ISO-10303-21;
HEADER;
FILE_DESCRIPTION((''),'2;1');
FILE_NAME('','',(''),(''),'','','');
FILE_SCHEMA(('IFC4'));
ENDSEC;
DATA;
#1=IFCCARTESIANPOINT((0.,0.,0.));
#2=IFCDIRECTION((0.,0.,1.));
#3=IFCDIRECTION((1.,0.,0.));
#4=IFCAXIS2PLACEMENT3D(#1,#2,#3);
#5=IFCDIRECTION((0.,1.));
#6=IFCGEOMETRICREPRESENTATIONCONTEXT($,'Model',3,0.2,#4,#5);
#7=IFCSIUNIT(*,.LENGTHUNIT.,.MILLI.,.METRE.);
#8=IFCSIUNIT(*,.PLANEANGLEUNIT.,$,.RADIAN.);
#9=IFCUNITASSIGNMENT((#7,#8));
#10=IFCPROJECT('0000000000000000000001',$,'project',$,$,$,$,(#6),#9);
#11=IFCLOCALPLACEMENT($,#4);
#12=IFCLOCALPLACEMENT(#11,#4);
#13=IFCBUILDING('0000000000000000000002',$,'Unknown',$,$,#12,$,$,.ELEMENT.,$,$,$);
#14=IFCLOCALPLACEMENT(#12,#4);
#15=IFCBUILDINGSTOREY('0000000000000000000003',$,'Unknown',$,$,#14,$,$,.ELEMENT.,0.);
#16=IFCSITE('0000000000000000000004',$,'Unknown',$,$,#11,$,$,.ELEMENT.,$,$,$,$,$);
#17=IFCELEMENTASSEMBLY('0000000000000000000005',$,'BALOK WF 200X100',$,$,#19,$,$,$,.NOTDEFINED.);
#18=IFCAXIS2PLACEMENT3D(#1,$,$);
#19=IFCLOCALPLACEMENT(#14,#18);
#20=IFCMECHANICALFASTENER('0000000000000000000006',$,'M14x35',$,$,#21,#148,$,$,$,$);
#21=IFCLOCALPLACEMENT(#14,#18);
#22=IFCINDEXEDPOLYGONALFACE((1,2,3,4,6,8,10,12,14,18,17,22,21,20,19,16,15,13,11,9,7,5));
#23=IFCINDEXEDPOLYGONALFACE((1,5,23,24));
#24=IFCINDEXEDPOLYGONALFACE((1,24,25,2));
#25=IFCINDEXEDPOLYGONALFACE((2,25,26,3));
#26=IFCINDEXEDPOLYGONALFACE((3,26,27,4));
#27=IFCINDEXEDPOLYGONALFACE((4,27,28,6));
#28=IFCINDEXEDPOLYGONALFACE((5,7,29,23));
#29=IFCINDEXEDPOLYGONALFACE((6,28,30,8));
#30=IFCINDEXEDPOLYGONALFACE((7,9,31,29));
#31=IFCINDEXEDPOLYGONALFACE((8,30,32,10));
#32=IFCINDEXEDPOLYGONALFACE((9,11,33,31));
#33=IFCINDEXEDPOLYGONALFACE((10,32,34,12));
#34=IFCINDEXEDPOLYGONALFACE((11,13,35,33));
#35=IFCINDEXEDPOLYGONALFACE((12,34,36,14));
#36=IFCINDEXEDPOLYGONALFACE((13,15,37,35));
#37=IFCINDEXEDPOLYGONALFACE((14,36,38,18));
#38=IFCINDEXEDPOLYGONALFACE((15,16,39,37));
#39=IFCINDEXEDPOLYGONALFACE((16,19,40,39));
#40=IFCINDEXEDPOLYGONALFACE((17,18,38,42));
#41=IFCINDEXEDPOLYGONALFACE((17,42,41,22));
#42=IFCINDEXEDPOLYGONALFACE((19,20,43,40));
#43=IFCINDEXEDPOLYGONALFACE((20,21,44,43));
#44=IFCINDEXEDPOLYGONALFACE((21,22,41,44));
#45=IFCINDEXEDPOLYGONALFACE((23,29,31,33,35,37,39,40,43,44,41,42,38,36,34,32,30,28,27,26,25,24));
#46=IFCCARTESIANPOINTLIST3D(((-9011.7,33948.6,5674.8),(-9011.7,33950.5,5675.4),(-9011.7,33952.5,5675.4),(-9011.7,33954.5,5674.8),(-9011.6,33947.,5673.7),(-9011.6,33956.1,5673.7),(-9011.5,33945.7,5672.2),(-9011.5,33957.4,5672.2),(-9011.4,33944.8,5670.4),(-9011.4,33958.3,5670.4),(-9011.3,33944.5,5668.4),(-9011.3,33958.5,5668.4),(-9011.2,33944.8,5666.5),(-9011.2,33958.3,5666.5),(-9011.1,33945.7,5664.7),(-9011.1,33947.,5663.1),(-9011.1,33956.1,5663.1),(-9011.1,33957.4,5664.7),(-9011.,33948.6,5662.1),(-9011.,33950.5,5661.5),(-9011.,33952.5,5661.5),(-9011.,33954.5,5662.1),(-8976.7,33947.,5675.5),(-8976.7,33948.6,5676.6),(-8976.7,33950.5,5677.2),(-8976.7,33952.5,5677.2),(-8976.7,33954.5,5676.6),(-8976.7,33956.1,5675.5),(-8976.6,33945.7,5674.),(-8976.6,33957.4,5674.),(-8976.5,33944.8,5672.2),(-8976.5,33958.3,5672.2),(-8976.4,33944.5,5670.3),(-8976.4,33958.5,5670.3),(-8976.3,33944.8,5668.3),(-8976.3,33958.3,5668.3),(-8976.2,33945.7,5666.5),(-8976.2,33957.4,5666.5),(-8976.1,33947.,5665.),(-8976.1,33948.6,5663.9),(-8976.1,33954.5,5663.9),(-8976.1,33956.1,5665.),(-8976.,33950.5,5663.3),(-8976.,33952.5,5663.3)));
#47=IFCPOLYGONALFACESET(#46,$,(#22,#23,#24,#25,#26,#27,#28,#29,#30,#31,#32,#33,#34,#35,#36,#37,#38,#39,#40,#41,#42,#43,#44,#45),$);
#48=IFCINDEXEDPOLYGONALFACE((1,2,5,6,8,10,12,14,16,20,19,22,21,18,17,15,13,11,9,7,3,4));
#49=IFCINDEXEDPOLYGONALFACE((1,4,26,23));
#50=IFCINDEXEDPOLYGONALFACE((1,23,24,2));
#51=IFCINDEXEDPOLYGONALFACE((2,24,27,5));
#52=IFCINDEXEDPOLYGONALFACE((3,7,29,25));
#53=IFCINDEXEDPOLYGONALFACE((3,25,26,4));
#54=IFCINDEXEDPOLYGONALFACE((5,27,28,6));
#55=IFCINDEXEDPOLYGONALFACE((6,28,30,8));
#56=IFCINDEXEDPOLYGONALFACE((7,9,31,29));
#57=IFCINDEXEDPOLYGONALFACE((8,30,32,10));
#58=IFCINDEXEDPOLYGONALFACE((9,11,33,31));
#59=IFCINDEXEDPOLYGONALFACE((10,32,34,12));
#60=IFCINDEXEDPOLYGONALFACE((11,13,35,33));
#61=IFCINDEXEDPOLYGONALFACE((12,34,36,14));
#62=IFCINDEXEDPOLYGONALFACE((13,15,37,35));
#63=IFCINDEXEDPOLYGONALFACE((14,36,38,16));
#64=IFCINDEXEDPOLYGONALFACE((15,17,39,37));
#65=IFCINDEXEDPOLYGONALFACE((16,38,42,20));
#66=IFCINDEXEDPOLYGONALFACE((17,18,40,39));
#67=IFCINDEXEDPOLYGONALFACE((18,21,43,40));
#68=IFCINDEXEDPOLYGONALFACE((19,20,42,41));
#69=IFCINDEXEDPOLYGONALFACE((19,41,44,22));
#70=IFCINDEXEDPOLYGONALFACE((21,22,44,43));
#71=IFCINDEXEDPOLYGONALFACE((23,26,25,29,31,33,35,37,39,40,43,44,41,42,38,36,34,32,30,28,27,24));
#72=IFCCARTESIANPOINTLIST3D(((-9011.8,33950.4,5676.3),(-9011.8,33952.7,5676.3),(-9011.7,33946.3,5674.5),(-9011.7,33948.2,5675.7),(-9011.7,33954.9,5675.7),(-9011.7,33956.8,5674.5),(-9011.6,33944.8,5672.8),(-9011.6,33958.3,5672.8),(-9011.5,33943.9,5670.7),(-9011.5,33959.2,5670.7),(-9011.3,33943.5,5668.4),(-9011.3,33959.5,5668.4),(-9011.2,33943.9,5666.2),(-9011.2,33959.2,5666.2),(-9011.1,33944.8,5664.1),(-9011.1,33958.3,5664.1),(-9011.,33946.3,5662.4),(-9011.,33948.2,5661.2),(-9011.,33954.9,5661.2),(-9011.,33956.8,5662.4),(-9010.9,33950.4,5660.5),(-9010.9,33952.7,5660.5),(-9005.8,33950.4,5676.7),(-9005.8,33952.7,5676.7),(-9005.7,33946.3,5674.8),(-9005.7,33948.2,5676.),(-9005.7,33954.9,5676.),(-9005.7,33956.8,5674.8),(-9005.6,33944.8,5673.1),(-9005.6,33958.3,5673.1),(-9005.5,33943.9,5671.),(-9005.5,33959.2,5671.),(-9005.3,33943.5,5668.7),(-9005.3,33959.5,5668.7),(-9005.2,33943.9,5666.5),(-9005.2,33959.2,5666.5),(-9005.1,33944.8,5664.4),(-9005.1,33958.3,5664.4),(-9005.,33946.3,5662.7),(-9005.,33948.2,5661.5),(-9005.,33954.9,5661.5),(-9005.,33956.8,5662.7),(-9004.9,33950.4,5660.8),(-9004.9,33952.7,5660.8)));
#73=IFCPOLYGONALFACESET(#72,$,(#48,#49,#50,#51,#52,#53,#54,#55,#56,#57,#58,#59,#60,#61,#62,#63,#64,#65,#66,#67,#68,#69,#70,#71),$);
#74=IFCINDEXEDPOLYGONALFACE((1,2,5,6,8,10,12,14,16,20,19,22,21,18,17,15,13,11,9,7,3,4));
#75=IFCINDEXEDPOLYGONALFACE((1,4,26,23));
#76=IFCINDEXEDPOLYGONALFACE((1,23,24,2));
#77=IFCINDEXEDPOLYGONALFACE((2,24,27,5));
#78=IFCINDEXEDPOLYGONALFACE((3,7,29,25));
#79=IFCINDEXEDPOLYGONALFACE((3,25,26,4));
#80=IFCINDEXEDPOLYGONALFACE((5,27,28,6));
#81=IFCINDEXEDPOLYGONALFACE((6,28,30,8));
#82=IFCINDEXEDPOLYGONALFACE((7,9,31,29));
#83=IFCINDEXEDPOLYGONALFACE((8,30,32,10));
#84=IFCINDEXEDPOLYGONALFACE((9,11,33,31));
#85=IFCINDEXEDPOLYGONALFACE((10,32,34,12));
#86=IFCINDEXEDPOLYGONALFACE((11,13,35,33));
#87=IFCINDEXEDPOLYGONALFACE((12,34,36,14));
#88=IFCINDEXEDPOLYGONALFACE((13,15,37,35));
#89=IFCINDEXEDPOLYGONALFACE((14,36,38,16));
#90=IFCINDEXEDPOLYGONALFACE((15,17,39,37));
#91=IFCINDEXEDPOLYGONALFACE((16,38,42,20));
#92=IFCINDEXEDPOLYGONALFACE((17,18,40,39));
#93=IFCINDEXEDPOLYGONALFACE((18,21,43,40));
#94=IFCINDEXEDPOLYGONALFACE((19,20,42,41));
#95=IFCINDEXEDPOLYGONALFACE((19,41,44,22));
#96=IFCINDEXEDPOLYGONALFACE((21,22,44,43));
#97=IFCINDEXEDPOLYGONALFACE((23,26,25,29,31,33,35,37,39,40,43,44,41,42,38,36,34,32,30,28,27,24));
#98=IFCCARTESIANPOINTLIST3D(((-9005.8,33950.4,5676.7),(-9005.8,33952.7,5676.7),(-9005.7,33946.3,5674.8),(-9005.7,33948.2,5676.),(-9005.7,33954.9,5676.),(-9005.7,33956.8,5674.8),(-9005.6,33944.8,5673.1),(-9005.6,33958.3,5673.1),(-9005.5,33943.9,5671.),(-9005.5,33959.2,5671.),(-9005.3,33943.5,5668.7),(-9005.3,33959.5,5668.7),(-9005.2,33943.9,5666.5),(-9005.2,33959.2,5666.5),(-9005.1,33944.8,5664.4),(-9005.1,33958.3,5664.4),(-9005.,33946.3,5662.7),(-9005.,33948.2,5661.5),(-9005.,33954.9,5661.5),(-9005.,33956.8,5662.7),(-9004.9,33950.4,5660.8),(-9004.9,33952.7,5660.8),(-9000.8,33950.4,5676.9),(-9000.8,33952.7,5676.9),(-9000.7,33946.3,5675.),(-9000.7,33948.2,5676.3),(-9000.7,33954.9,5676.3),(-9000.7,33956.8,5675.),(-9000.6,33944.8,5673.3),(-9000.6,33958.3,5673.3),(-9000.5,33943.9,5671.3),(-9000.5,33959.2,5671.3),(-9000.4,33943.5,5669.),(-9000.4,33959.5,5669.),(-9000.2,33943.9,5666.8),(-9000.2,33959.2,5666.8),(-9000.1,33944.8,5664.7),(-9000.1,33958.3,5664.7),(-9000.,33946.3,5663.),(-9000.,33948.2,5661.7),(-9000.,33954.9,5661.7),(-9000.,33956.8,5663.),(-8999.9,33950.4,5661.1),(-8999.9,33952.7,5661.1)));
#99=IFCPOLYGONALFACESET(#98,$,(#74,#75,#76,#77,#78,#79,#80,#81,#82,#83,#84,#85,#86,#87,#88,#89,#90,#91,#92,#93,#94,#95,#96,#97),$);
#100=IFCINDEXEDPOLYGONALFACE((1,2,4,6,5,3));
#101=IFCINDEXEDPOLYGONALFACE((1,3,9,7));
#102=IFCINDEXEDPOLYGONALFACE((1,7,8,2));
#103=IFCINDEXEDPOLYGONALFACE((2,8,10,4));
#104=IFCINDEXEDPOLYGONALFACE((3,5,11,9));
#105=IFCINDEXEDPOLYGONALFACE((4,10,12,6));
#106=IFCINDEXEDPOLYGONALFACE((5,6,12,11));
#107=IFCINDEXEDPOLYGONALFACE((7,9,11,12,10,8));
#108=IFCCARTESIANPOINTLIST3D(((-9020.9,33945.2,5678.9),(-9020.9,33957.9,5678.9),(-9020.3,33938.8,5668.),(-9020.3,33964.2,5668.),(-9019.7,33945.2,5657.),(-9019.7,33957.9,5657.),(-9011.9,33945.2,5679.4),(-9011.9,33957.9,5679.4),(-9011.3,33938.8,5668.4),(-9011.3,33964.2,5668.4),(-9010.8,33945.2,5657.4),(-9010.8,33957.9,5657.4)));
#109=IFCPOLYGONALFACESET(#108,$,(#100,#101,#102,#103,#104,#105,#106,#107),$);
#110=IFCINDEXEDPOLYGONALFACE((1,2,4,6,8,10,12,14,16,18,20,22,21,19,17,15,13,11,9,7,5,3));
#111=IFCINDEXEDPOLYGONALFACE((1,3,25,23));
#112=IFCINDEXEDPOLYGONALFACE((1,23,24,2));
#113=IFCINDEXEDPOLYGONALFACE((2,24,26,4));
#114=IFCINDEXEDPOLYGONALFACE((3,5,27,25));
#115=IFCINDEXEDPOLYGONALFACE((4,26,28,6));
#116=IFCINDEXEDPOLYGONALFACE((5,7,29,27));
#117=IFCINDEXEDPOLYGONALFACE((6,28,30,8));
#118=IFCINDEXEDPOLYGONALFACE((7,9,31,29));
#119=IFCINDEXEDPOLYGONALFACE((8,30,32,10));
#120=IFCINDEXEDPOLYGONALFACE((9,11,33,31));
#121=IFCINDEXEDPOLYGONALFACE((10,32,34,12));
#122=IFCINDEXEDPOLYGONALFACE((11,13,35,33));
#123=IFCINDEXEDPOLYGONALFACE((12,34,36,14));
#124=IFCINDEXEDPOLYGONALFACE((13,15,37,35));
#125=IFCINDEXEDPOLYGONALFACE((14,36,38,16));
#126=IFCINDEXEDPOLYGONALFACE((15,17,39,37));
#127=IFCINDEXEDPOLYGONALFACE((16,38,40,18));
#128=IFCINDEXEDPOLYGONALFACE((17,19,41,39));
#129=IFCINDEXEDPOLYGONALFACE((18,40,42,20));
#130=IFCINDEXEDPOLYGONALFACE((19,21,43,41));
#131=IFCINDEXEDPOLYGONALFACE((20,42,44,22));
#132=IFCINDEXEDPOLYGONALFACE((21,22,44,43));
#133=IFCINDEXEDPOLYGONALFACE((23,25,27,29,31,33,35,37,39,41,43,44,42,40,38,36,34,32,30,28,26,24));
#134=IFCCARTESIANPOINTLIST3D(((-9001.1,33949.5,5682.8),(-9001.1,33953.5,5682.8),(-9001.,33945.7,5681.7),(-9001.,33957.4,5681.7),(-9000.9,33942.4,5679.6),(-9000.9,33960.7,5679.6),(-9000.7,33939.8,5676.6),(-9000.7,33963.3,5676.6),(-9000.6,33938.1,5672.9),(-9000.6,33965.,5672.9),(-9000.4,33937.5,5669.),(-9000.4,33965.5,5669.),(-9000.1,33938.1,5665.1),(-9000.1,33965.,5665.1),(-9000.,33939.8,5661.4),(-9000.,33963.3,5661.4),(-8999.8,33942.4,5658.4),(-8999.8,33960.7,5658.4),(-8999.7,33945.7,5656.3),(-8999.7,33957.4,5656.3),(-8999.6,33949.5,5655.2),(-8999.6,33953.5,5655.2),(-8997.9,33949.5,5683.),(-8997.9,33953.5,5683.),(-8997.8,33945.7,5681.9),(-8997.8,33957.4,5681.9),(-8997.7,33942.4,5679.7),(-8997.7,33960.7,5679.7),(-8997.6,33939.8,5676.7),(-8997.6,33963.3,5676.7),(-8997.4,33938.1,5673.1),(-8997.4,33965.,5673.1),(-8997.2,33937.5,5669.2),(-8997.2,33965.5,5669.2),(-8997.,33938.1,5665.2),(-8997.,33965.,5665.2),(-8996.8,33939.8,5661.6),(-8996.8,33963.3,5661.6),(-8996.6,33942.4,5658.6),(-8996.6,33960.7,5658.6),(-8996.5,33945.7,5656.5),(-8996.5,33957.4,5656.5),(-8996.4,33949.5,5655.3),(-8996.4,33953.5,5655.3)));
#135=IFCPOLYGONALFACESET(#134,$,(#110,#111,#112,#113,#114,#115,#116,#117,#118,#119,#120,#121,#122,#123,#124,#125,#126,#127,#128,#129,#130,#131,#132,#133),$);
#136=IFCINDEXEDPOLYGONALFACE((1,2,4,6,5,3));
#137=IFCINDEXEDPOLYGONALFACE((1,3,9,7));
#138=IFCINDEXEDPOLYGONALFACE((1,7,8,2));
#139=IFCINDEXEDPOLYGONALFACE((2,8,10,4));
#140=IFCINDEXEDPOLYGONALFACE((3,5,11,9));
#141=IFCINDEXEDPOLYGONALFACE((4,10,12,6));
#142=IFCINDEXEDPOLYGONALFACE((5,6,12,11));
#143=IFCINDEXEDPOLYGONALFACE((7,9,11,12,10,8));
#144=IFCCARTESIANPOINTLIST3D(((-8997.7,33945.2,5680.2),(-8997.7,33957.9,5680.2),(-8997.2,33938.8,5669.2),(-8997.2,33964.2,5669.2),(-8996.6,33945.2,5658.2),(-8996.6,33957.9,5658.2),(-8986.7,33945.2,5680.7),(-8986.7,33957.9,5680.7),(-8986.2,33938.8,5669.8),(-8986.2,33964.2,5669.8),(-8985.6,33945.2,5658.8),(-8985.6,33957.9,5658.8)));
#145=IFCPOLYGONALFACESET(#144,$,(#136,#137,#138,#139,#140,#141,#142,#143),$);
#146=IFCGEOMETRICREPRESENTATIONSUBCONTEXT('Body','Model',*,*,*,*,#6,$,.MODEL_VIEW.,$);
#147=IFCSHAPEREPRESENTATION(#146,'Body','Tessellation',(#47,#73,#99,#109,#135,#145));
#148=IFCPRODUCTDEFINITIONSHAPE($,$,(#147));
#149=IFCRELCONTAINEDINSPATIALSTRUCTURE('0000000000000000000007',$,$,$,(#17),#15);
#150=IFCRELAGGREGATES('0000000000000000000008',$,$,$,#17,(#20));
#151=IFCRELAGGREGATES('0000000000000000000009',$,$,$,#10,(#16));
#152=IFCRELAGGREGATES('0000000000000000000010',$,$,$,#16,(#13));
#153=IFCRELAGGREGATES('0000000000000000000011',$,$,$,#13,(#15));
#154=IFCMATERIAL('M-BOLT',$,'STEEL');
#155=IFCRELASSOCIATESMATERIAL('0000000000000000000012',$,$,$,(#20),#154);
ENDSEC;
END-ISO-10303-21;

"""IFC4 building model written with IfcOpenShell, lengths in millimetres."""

from ifc_helpers import new_model, si_unit, direction, frame, origin_with_axes, place, context, subcontext, project, spatial, line, arc, indexed_curve, outline, extrude, source, transform, mapped, material, element, aggregate, save


model = new_model("IFC4")

# Units and contexts
model_context = context("Model", 3, precision=0.2, world=origin_with_axes(), true_north=direction((0.0, 1.0)))
body_context = subcontext(model_context, "Body", "Model", "MODEL_VIEW")
ifc_project = project(units=[si_unit("LENGTHUNIT", "METRE", prefix="MILLI"), si_unit("PLANEANGLEUNIT", "RADIAN")], contexts=[model_context])

# Site, building, storey
site_placement = place(None, origin_with_axes())
site = spatial("IfcSite", under=ifc_project, at=site_placement, Name="Unknown", CompositionType="ELEMENT")
building_placement = place(site_placement, origin_with_axes())
building = spatial("IfcBuilding", under=site, at=building_placement, Name="Unknown", CompositionType="ELEMENT")
storey_placement = place(building_placement, origin_with_axes())
storey = spatial("IfcBuildingStorey", under=building, at=storey_placement, Name="Unknown", CompositionType="ELEMENT", Elevation=0.0)

# Element assembly
assembly_1_placement = place(storey_placement, frame((-7044.1, 33866.5, 5721.5), z_axis=(0.0, 1.0, 0.0), x_axis=(-0.99863, 0.0, -0.052336)))
assembly_1 = element("IfcElementAssembly", 1, at=assembly_1_placement, inside=storey, Name="BALOK WF 200X100", PredefinedType="NOTDEFINED")

# Mechanical fastener
ifc_material_1 = material(Name="M-BOLT", Category="STEEL")
shared_shape_1 = source(origin_with_axes(), body_context, "Body", "SweptSolid", [
    extrude(outline(indexed_curve([(7.0, 0.0), (0.0, 7.0), (-7.0, 0.0), (0.0, -7.0)], segments=[arc(1, 2, 3), arc(3, 4, 1)])), frame((0.0, 0.0, 0.0), z_axis=(0.0, 0.0, -1.0), x_axis=(0.0, 1.0, 0.0)), (0.0, 0.0, 1.0), 35.0),
    extrude(outline(indexed_curve([(8.0, 0.0), (0.0, 8.0), (-8.0, 0.0), (0.0, -8.0)], segments=[arc(1, 2, 3), arc(3, 4, 1)])), frame((0.0, 0.0, 0.0), z_axis=(0.0, 0.0, -1.0), x_axis=(0.0, 1.0, 0.0)), (0.0, 0.0, 1.0), 6.0),
    extrude(outline(indexed_curve([(8.0, 0.0), (0.0, 8.0), (-8.0, 0.0), (0.0, -8.0)], segments=[arc(1, 2, 3), arc(3, 4, 1)])), frame((0.0, 0.0, -6.0), z_axis=(0.0, 0.0, -1.0), x_axis=(0.0, 1.0, 0.0)), (0.0, 0.0, 1.0), 5.0),
    extrude(outline(indexed_curve([(12.7, 0.0), (6.4, 11.0), (-6.4, 11.0), (-12.7, 0.0), (-6.4, -11.0), (6.4, -11.0)], segments=[line(1, 2, 3, 4, 5, 6, 1)])), frame((0.0, 0.0, 9.0), z_axis=(0.0, 0.0, -1.0), x_axis=(0.0, 1.0, 0.0)), (0.0, 0.0, 1.0), 9.0),
    extrude(outline(indexed_curve([(14.0, 0.0), (0.0, 14.0), (-14.0, 0.0), (0.0, -14.0)], segments=[arc(1, 2, 3), arc(3, 4, 1)])), frame((0.0, 0.0, -11.0), z_axis=(0.0, 0.0, -1.0), x_axis=(0.0, 1.0, 0.0)), (0.0, 0.0, 1.0), 3.2),
    extrude(outline(indexed_curve([(12.7, 0.0), (6.4, 11.0), (-6.4, 11.0), (-12.7, 0.0), (-6.4, -11.0), (6.4, -11.0)], segments=[line(1, 2, 3, 4, 5, 6, 1)])), frame((0.0, 0.0, -14.2), z_axis=(0.0, 0.0, -1.0), x_axis=(0.0, 1.0, 0.0)), (0.0, 0.0, 1.0), 11.0),
])
mechanical_fastener_1_placement = place(assembly_1_placement, frame((1967.3, 50.0, 85.0), z_axis=(1.0, 0.0, 0.000006), x_axis=(0.0, -1.0, 0.0)))
mechanical_fastener_1 = element("IfcMechanicalFastener", 2, at=mechanical_fastener_1_placement, material=ifc_material_1, Name="M14x35", context=body_context, shape_type="MappedRepresentation", body=[
    mapped(shared_shape_1, transform((0.0, 0.0, 0.0))),
])
aggregate(assembly_1, [mechanical_fastener_1])

save(model, "model.ifc")
